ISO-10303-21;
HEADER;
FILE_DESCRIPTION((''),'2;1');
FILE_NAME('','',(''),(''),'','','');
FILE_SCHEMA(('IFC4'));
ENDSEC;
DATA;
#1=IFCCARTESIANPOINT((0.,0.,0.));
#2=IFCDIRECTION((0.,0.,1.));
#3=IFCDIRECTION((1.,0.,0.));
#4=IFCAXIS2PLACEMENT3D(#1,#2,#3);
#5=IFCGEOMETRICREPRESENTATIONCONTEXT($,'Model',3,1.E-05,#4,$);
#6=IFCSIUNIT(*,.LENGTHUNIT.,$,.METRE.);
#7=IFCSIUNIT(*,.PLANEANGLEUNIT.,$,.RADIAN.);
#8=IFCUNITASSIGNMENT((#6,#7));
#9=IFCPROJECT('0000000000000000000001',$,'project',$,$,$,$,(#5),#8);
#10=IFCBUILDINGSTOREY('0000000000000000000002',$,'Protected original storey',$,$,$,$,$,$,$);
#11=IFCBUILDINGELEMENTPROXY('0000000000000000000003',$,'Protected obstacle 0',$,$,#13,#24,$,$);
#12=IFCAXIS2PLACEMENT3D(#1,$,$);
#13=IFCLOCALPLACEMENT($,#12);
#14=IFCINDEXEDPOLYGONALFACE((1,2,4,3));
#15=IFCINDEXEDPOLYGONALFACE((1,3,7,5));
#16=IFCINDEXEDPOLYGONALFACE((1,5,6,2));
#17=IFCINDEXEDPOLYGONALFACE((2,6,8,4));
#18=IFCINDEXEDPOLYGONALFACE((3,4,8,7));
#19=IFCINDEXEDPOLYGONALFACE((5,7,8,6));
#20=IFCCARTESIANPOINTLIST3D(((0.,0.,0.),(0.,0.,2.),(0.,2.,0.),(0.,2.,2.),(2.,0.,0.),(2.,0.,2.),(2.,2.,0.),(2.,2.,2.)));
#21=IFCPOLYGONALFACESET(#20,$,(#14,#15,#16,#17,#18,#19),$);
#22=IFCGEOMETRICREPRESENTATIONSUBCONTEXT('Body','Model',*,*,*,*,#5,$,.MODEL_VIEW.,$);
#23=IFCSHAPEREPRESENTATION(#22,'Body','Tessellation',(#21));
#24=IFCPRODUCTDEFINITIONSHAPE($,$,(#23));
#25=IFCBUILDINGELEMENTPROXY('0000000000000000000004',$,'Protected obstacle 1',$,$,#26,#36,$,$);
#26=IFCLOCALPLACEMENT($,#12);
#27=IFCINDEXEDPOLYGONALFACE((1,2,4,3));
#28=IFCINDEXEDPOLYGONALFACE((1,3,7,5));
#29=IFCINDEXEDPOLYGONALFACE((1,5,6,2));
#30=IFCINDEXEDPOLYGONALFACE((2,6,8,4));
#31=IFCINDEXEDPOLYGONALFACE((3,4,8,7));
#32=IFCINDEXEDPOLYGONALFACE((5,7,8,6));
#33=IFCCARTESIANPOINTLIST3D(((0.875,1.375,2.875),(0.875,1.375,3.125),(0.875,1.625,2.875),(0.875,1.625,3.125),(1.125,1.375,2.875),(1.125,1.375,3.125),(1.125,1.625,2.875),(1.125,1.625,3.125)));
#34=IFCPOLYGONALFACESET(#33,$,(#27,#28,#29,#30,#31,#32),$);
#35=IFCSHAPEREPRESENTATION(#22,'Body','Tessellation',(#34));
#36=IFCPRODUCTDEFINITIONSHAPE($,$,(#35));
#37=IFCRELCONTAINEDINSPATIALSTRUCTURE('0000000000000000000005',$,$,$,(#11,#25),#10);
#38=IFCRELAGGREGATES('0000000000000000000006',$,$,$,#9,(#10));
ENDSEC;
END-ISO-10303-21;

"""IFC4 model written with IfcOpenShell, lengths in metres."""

from ifc_helpers import new_model, si_unit, frame, origin_with_axes, place, context, subcontext, project, spatial, indexed_curve, outline, extrude, element, save


model = new_model("IFC4")

# Units and contexts
model_context = context("Model", 3, precision=1e-05, world=origin_with_axes())
body_context = subcontext(model_context, "Body", "Model", "MODEL_VIEW")
ifc_project = project(units=[si_unit("LENGTHUNIT", "METRE"), si_unit("PLANEANGLEUNIT", "RADIAN")], contexts=[model_context])

# Storey
storey = spatial("IfcBuildingStorey", under=ifc_project, Name="Protected original storey")

# Building element proxies
proxy_1_placement = place(None, origin_with_axes())
element("IfcBuildingElementProxy", 1, at=proxy_1_placement, inside=storey, Name="Protected obstacle 0", context=body_context, shape_type="SweptSolid", body=[
    extrude(outline(indexed_curve([(0.0, 0.0), (0.0, 2.0), (2.0, 2.0), (2.0, 0.0), (0.0, 0.0)], self_intersect=False)), origin_with_axes(), (0.0, 0.0, 1.0), 2.0),
])
proxy_2_placement = place(None, frame((0.875, 1.375, 2.875), z_axis=(0.0, 0.0, 1.0), x_axis=(1.0, 0.0, 0.0)))
element("IfcBuildingElementProxy", 2, at=proxy_2_placement, inside=storey, Name="Protected obstacle 1", context=body_context, shape_type="SweptSolid", body=[
    extrude(outline(indexed_curve([(0.0, 0.0), (0.0, 0.25), (0.25, 0.25), (0.25, 0.0), (0.0, 0.0)], self_intersect=False)), origin_with_axes(), (0.0, 0.0, 1.0), 0.25),
])

save(model, "model.ifc")
